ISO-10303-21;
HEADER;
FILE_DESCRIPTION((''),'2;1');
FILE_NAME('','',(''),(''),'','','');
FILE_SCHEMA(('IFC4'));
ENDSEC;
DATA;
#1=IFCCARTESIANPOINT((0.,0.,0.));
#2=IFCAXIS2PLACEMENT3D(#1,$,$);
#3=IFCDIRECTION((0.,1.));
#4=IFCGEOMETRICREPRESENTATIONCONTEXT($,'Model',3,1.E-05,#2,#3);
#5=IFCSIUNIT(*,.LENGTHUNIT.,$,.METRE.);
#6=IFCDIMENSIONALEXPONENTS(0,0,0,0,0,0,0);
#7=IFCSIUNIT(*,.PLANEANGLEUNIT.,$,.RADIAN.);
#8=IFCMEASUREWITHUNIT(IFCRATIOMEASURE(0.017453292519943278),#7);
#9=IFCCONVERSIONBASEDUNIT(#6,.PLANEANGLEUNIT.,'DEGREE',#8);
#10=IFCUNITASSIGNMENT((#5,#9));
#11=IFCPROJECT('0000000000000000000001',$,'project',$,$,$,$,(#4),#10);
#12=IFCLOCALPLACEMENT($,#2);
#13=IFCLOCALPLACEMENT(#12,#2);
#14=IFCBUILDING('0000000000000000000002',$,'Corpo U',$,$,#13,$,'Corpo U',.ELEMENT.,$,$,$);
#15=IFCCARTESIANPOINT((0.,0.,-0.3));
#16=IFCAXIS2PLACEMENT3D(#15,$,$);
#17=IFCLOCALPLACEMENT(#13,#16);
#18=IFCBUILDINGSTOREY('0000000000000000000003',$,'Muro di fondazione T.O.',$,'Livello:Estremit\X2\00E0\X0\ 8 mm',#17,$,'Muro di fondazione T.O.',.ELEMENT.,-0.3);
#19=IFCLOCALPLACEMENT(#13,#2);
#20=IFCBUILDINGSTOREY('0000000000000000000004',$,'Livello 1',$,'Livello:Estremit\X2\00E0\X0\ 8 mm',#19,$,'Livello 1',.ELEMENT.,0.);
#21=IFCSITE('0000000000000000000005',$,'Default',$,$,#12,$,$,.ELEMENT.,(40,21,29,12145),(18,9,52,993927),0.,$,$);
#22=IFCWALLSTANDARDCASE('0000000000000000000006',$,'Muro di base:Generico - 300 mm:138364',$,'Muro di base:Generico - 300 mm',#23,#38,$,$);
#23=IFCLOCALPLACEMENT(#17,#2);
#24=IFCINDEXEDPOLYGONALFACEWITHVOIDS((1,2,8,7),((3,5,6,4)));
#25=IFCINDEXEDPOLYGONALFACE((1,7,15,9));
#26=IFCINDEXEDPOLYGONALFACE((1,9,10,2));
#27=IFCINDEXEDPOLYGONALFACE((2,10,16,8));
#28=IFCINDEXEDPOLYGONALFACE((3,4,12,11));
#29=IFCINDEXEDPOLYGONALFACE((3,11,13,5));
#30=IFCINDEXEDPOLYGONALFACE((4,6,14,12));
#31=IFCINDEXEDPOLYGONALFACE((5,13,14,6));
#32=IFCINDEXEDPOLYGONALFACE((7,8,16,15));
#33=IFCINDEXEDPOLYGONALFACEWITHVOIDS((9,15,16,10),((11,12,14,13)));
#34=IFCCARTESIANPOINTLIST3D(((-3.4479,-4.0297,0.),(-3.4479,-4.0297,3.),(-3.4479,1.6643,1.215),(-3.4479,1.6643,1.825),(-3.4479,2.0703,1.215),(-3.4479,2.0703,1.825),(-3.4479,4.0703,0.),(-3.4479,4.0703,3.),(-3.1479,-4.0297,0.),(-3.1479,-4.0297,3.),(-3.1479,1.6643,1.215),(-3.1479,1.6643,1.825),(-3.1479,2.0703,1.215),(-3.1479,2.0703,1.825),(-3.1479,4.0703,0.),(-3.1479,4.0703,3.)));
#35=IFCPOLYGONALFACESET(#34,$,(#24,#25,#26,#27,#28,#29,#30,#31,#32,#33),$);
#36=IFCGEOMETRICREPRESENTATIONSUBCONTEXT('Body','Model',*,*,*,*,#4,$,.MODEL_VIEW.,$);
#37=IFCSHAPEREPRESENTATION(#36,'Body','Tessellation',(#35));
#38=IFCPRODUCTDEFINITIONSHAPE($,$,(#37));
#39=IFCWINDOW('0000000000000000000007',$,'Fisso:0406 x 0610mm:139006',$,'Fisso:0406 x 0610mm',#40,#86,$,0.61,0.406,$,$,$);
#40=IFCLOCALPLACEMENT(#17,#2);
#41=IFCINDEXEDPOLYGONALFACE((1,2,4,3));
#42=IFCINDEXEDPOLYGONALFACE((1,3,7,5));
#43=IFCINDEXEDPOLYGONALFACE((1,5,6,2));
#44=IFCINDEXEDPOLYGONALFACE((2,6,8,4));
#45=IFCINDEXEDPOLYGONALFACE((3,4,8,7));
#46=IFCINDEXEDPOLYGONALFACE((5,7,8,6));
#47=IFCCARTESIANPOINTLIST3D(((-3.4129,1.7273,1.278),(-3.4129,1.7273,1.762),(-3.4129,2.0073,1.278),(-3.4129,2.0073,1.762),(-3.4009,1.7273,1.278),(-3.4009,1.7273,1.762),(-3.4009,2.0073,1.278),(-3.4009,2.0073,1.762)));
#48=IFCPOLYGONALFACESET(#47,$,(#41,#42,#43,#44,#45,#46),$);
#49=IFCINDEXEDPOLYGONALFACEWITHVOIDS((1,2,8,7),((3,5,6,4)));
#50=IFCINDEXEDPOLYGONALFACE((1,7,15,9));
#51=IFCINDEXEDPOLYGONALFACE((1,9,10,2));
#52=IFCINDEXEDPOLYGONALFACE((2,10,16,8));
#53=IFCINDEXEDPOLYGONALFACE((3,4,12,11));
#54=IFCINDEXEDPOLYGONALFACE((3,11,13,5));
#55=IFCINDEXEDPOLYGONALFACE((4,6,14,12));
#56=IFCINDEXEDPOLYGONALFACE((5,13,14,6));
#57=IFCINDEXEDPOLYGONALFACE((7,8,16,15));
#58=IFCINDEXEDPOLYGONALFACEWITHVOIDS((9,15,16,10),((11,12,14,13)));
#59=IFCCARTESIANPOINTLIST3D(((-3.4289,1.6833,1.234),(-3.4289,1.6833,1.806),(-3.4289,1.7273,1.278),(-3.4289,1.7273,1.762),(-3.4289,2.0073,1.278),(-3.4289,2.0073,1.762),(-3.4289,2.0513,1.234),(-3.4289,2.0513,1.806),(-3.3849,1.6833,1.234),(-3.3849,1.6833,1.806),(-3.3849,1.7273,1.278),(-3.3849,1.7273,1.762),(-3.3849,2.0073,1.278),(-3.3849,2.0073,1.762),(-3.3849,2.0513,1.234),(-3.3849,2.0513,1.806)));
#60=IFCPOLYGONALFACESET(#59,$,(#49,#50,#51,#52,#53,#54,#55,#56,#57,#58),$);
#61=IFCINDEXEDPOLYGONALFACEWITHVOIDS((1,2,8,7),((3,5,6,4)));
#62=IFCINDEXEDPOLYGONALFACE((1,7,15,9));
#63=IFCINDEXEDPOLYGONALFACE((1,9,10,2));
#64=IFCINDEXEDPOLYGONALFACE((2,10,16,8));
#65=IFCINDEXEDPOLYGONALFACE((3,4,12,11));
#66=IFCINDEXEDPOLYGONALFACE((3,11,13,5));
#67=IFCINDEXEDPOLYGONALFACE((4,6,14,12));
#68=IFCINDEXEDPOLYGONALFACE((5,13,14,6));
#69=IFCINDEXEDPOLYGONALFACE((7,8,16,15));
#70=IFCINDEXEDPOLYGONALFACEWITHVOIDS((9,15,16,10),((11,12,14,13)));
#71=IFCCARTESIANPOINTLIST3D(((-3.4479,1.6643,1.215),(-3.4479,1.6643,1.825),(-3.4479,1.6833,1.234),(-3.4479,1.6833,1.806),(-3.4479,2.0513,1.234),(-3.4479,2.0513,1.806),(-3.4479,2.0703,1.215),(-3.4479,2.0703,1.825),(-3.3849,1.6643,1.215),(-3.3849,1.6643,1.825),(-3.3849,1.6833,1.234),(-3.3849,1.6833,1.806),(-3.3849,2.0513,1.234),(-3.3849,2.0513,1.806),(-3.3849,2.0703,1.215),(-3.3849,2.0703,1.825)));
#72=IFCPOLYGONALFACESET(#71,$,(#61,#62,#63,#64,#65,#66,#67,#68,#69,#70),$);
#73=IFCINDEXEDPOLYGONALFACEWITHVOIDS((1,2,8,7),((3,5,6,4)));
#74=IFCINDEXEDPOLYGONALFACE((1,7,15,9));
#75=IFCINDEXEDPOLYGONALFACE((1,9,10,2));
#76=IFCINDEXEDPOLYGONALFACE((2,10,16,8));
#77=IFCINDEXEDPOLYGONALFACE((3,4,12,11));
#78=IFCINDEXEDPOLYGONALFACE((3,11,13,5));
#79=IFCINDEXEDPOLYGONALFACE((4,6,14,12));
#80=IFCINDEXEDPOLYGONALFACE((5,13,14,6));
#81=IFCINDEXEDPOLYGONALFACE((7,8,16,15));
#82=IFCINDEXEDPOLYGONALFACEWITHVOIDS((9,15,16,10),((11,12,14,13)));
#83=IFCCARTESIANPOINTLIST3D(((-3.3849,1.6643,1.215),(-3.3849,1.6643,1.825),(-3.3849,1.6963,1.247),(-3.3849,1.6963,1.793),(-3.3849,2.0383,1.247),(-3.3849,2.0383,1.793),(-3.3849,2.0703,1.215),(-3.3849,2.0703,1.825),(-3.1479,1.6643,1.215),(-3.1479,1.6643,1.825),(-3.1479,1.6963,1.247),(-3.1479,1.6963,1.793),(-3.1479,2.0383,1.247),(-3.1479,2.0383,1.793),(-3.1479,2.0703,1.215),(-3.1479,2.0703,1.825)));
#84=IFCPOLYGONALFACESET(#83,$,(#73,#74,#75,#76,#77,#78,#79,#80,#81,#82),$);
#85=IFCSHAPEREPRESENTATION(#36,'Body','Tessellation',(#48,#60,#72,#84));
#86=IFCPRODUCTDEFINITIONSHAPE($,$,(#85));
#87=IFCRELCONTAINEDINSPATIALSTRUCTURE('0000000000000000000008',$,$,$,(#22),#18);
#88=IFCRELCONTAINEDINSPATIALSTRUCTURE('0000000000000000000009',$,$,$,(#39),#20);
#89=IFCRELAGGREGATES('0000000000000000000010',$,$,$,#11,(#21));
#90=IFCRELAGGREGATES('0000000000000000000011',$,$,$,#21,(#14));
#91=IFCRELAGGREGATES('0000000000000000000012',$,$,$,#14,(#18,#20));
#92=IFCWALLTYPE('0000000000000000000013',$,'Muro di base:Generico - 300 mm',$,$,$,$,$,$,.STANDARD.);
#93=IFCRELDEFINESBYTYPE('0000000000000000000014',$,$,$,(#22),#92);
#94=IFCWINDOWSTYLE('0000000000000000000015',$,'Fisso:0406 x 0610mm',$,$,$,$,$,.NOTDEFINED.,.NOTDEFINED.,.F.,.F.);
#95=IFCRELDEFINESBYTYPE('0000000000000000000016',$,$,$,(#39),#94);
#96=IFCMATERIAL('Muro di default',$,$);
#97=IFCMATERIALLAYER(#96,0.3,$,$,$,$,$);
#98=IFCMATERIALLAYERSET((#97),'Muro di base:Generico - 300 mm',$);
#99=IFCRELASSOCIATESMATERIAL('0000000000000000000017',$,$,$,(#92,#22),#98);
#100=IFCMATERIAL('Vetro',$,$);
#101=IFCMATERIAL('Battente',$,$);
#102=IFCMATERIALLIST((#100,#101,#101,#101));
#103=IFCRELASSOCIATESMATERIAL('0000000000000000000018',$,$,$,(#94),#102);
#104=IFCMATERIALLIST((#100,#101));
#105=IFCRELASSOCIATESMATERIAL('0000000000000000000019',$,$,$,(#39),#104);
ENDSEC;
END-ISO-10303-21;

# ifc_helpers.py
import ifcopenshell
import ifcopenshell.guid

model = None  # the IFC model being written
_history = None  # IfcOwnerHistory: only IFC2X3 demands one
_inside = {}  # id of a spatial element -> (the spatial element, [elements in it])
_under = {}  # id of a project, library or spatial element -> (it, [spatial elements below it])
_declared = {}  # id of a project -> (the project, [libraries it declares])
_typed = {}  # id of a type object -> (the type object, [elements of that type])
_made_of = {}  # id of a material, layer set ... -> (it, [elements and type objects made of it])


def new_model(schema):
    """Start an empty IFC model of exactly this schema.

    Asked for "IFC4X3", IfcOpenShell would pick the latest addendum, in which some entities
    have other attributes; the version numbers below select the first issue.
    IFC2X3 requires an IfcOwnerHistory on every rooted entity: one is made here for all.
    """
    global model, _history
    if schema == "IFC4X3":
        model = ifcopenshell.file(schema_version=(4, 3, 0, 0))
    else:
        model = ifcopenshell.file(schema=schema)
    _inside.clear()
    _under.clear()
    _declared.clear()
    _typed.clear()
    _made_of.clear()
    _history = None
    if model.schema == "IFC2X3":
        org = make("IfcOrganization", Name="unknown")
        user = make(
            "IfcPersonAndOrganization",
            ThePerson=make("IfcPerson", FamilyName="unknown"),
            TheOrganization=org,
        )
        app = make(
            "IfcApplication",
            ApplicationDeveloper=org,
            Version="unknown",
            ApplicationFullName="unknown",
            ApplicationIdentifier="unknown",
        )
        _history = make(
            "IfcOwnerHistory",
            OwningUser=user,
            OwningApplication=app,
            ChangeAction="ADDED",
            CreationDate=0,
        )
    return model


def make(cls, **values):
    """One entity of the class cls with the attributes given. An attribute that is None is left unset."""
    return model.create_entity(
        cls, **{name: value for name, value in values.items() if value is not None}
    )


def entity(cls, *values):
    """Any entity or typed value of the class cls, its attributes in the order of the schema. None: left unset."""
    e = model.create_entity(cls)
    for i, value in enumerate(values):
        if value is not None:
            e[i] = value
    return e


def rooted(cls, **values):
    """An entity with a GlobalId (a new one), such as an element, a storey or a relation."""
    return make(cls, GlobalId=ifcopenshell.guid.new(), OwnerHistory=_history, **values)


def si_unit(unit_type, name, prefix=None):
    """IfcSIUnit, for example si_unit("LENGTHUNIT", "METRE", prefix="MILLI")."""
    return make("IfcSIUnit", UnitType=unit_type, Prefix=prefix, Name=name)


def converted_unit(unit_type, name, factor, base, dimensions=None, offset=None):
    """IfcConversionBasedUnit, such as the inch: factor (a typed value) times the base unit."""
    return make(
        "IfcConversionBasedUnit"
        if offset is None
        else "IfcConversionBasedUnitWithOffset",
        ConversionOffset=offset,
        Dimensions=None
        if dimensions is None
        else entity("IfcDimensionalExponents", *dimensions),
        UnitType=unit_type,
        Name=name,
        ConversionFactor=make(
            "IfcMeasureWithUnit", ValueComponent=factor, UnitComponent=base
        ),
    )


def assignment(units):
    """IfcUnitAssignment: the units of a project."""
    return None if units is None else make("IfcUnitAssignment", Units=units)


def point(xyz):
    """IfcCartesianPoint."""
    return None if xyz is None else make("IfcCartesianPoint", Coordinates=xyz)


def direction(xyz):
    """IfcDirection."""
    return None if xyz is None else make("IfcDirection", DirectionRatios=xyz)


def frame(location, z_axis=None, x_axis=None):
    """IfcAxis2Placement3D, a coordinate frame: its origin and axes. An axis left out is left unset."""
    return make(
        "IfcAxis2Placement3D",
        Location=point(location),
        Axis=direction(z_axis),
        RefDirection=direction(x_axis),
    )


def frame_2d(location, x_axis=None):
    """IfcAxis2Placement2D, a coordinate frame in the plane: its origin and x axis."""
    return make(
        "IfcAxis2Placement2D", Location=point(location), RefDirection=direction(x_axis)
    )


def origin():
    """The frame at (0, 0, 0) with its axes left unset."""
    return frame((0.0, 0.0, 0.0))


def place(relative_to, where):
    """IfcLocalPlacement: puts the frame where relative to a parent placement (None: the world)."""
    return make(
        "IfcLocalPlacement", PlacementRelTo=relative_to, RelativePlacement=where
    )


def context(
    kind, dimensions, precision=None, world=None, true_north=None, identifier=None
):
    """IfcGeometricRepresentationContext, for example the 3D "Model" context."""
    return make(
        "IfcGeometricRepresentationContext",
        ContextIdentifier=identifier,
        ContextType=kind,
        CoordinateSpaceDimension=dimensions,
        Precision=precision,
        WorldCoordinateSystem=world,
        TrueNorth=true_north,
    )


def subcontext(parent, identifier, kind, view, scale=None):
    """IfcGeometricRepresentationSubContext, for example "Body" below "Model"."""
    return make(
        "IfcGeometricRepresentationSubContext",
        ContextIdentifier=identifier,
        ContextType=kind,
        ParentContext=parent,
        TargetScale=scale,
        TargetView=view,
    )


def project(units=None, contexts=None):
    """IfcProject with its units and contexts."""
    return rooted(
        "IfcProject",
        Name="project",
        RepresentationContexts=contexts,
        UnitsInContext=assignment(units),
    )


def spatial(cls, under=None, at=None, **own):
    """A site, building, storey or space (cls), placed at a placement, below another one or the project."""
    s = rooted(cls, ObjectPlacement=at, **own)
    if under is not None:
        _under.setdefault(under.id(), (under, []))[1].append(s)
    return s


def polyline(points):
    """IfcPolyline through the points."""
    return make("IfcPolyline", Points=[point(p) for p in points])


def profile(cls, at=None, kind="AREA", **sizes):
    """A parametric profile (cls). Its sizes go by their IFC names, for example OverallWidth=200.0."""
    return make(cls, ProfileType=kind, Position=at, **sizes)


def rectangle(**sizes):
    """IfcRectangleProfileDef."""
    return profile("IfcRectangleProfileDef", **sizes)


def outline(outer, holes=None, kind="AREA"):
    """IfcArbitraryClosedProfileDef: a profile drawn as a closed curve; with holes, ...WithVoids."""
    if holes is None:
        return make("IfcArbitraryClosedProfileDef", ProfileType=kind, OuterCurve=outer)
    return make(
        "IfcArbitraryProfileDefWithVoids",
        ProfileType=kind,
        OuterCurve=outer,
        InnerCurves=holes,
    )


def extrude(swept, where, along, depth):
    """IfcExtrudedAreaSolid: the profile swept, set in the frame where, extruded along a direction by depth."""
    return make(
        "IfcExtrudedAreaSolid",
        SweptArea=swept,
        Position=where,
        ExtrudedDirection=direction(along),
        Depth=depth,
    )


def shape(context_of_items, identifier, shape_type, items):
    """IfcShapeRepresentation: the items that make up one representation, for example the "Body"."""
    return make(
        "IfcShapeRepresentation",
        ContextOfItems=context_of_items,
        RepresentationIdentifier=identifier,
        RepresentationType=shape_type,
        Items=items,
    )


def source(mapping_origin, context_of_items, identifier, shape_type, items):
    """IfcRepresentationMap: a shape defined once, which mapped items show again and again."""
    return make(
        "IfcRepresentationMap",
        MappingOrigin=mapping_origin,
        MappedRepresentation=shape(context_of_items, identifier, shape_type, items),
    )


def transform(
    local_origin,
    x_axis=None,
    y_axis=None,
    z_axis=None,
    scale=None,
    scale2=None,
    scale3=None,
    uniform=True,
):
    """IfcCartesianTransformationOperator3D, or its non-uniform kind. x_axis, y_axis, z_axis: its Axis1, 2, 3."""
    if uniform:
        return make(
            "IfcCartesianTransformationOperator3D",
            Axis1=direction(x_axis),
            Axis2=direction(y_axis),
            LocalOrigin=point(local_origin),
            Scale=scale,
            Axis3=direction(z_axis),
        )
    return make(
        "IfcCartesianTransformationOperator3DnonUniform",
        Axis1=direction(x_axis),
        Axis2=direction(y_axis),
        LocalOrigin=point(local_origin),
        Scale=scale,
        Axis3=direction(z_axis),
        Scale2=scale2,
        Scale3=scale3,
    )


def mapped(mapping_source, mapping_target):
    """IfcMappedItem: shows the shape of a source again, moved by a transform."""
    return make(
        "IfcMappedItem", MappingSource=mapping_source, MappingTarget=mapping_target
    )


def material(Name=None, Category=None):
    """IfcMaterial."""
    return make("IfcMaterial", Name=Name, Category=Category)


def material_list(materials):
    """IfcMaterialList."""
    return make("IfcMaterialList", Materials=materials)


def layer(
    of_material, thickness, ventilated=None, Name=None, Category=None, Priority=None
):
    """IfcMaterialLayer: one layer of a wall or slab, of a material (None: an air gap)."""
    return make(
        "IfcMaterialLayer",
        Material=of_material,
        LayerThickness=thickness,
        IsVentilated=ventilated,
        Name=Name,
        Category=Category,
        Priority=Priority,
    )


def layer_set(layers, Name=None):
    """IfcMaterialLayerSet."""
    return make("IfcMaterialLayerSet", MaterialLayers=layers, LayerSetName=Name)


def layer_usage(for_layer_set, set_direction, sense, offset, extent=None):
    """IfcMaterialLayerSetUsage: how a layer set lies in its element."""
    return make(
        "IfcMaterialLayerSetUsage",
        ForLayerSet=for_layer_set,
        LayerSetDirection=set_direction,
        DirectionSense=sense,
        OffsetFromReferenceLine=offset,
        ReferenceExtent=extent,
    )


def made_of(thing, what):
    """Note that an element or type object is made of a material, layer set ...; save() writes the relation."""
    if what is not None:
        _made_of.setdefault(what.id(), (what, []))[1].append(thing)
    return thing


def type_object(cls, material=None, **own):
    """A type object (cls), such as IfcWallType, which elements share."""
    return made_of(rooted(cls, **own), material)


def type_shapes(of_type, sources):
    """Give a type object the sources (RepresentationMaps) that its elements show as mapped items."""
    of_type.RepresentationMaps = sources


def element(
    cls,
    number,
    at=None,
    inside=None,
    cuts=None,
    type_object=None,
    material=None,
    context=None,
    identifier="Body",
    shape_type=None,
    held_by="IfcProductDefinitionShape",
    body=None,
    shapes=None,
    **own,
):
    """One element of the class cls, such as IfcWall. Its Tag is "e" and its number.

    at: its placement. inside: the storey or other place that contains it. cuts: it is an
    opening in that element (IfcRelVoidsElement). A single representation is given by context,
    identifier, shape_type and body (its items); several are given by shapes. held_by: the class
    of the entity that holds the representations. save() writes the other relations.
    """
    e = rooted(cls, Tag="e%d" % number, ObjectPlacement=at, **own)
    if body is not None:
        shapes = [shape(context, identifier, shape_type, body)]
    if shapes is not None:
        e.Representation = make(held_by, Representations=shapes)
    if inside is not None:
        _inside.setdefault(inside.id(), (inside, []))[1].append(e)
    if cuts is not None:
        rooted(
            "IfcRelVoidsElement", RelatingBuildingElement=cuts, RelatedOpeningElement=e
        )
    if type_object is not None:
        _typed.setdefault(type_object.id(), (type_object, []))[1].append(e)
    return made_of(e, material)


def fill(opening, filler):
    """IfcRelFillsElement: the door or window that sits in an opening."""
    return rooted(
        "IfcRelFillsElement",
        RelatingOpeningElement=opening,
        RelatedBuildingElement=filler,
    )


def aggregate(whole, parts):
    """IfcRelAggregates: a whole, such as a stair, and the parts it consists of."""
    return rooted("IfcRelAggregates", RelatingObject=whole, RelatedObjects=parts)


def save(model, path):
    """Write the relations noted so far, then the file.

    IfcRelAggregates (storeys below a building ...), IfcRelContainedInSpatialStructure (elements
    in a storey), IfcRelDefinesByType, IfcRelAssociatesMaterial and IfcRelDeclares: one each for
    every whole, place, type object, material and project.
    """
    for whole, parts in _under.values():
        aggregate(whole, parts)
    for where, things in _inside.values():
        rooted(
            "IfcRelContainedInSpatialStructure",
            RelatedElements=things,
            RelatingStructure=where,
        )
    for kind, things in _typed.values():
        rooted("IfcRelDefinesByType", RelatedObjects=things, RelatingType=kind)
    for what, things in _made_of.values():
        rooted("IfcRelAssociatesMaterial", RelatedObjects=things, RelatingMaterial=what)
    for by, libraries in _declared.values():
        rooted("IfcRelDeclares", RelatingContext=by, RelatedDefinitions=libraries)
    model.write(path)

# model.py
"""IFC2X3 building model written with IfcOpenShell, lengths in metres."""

from ifc_helpers import new_model, entity, si_unit, converted_unit, direction, frame, frame_2d, origin, place, context, subcontext, project, spatial, polyline, rectangle, outline, extrude, source, transform, mapped, material, material_list, layer, layer_set, layer_usage, type_object, type_shapes, element, fill, save


model = new_model("IFC2X3")

# Units and contexts
model_context = context("Model", 3, precision=1e-05, world=origin(), true_north=direction((0.0, 1.0)))
body_context = subcontext(model_context, "Body", "Model", "MODEL_VIEW")
ifc_project = project(units=[si_unit("LENGTHUNIT", "METRE"), converted_unit("PLANEANGLEUNIT", "DEGREE", entity("IfcRatioMeasure", 0.017453292519943278), si_unit("PLANEANGLEUNIT", "RADIAN"), dimensions=[0, 0, 0, 0, 0, 0, 0])], contexts=[model_context])

# Site, building, storey
site_placement = place(None, origin())
site = spatial("IfcSite", under=ifc_project, at=site_placement, Name="Default", CompositionType="ELEMENT", RefLatitude=(40, 21, 29, 12145), RefLongitude=(18, 9, 52, 993927), RefElevation=0.0)
building_placement = place(site_placement, origin())
building = spatial("IfcBuilding", under=site, at=building_placement, Name="Corpo U", LongName="Corpo U", CompositionType="ELEMENT")
storey_1_placement = place(building_placement, frame((0.0, 0.0, -0.3)))
storey_1 = spatial("IfcBuildingStorey", under=building, at=storey_1_placement, Name="Muro di fondazione T.O.", ObjectType="Livello:Estremità 8 mm", LongName="Muro di fondazione T.O.", CompositionType="ELEMENT", Elevation=-0.3)

# Shared definitions
ifc_material_1 = material(Name="Muro di default")
ifc_layer = layer(ifc_material_1, 0.3)
ifc_layer_set = layer_set([ifc_layer], Name="Muro di base:Generico - 300 mm")
wall_type = type_object("IfcWallType", Name="Muro di base:Generico - 300 mm", PredefinedType="STANDARD", material=ifc_layer_set)

# Shared definitions
storey_2_placement = place(building_placement, origin())
storey_2 = spatial("IfcBuildingStorey", under=building, at=storey_2_placement, Name="Livello 1", ObjectType="Livello:Estremità 8 mm", LongName="Livello 1", CompositionType="ELEMENT", Elevation=0.0)

# Shared definitions
ifc_material_2 = material(Name="Vetro")
ifc_material_3 = material(Name="Battente")
ifc_material_list_1 = material_list([ifc_material_2, ifc_material_3, ifc_material_3, ifc_material_3])
window_style = type_object("IfcWindowStyle", Name="Fisso:0406 x 0610mm", ConstructionType="NOTDEFINED", OperationType="NOTDEFINED", ParameterTakesPrecedence=False, Sizeable=False, material=ifc_material_list_1)
shared_shape_1 = source(origin(), body_context, "Body", "SweptSolid", [
    extrude(rectangle(XDim=0.012, YDim=0.28, at=frame_2d((0.0, 0.0), x_axis=(1.0, 0.0))), frame((0.203, 0.259, 0.063), z_axis=(0.0, 0.0, 1.0), x_axis=(0.0, -1.0, 0.0)), (0.0, 0.0, 1.0), 0.484),
    extrude(outline(polyline([(-0.184, -0.286), (0.184, -0.286), (0.184, 0.286), (-0.184, 0.286), (-0.184, -0.286)]), holes=[polyline([(-0.14, -0.242), (-0.14, 0.242), (0.14, 0.242), (0.14, -0.242), (-0.14, -0.242)])]), frame((0.203, 0.237, 0.305), z_axis=(0.0, 1.0, 0.0), x_axis=(1.0, 0.0, 0.0)), (0.0, 0.0, 1.0), 0.044),
    extrude(outline(polyline([(-0.203, -0.305), (0.203, -0.305), (0.203, 0.305), (-0.203, 0.305), (-0.203, -0.305)]), holes=[polyline([(-0.184, -0.286), (-0.184, 0.286), (0.184, 0.286), (0.184, -0.286), (-0.184, -0.286)])]), frame((0.203, 0.237, 0.305), z_axis=(0.0, 1.0, 0.0), x_axis=(1.0, 0.0, 0.0)), (0.0, 0.0, 1.0), 0.063),
    extrude(outline(polyline([(-0.203, -0.305), (0.203, -0.305), (0.203, 0.305), (-0.203, 0.305), (-0.203, -0.305)]), holes=[polyline([(-0.171, -0.273), (-0.171, 0.273), (0.171, 0.273), (0.171, -0.273), (-0.171, -0.273)])]), frame((0.203, 0.0, 0.305), z_axis=(0.0, 1.0, 0.0), x_axis=(1.0, 0.0, 0.0)), (0.0, 0.0, 1.0), 0.237),
])
type_shapes(window_style, [shared_shape_1])

# Wall, opening, window
ifc_layer_usage_1 = layer_usage(ifc_layer_set, "AXIS2", "NEGATIVE", 0.15)
wall_1_placement = place(storey_1_placement, frame((-3.2979, -4.0297, 0.0), z_axis=(0.0, 0.0, 1.0), x_axis=(0.0, 1.0, 0.0)))
wall_1 = element("IfcWallStandardCase", 1, at=wall_1_placement, inside=storey_1, type_object=wall_type, material=ifc_layer_usage_1, Name="Muro di base:Generico - 300 mm:138364", ObjectType="Muro di base:Generico - 300 mm", context=body_context, shape_type="SweptSolid", body=[
    extrude(rectangle(XDim=8.1, YDim=0.3, at=frame_2d((4.05, 0.0), x_axis=(-1.0, 0.0))), origin(), (0.0, 0.0, 1.0), 3.0),
])
opening_1_placement = place(wall_1_placement, frame((5.694, -0.15, 1.215)))
opening_1 = element("IfcOpeningElement", 2, at=opening_1_placement, cuts=wall_1, ObjectType="Opening", context=body_context, shape_type="SweptSolid", body=[
    extrude(rectangle(XDim=0.61, YDim=0.406, at=frame_2d((0.305, 0.203), x_axis=(1.0, 0.0))), frame((0.0, 0.0, 0.0), z_axis=(0.0, 1.0, 0.0), x_axis=(0.0, 0.0, 1.0)), (0.0, 0.0, 1.0), 0.3),
])
ifc_material_list_2 = material_list([ifc_material_2, ifc_material_3])
window_1_placement = place(opening_1_placement, origin())
window_1 = element("IfcWindow", 3, at=window_1_placement, inside=storey_2, type_object=window_style, material=ifc_material_list_2, Name="Fisso:0406 x 0610mm:139006", ObjectType="Fisso:0406 x 0610mm", OverallHeight=0.61, OverallWidth=0.406, context=body_context, shape_type="MappedRepresentation", body=[
    mapped(shared_shape_1, transform((0.0, 0.0, 0.0), scale=1.0)),
])
fill(opening_1, window_1)

save(model, "model.ifc")
